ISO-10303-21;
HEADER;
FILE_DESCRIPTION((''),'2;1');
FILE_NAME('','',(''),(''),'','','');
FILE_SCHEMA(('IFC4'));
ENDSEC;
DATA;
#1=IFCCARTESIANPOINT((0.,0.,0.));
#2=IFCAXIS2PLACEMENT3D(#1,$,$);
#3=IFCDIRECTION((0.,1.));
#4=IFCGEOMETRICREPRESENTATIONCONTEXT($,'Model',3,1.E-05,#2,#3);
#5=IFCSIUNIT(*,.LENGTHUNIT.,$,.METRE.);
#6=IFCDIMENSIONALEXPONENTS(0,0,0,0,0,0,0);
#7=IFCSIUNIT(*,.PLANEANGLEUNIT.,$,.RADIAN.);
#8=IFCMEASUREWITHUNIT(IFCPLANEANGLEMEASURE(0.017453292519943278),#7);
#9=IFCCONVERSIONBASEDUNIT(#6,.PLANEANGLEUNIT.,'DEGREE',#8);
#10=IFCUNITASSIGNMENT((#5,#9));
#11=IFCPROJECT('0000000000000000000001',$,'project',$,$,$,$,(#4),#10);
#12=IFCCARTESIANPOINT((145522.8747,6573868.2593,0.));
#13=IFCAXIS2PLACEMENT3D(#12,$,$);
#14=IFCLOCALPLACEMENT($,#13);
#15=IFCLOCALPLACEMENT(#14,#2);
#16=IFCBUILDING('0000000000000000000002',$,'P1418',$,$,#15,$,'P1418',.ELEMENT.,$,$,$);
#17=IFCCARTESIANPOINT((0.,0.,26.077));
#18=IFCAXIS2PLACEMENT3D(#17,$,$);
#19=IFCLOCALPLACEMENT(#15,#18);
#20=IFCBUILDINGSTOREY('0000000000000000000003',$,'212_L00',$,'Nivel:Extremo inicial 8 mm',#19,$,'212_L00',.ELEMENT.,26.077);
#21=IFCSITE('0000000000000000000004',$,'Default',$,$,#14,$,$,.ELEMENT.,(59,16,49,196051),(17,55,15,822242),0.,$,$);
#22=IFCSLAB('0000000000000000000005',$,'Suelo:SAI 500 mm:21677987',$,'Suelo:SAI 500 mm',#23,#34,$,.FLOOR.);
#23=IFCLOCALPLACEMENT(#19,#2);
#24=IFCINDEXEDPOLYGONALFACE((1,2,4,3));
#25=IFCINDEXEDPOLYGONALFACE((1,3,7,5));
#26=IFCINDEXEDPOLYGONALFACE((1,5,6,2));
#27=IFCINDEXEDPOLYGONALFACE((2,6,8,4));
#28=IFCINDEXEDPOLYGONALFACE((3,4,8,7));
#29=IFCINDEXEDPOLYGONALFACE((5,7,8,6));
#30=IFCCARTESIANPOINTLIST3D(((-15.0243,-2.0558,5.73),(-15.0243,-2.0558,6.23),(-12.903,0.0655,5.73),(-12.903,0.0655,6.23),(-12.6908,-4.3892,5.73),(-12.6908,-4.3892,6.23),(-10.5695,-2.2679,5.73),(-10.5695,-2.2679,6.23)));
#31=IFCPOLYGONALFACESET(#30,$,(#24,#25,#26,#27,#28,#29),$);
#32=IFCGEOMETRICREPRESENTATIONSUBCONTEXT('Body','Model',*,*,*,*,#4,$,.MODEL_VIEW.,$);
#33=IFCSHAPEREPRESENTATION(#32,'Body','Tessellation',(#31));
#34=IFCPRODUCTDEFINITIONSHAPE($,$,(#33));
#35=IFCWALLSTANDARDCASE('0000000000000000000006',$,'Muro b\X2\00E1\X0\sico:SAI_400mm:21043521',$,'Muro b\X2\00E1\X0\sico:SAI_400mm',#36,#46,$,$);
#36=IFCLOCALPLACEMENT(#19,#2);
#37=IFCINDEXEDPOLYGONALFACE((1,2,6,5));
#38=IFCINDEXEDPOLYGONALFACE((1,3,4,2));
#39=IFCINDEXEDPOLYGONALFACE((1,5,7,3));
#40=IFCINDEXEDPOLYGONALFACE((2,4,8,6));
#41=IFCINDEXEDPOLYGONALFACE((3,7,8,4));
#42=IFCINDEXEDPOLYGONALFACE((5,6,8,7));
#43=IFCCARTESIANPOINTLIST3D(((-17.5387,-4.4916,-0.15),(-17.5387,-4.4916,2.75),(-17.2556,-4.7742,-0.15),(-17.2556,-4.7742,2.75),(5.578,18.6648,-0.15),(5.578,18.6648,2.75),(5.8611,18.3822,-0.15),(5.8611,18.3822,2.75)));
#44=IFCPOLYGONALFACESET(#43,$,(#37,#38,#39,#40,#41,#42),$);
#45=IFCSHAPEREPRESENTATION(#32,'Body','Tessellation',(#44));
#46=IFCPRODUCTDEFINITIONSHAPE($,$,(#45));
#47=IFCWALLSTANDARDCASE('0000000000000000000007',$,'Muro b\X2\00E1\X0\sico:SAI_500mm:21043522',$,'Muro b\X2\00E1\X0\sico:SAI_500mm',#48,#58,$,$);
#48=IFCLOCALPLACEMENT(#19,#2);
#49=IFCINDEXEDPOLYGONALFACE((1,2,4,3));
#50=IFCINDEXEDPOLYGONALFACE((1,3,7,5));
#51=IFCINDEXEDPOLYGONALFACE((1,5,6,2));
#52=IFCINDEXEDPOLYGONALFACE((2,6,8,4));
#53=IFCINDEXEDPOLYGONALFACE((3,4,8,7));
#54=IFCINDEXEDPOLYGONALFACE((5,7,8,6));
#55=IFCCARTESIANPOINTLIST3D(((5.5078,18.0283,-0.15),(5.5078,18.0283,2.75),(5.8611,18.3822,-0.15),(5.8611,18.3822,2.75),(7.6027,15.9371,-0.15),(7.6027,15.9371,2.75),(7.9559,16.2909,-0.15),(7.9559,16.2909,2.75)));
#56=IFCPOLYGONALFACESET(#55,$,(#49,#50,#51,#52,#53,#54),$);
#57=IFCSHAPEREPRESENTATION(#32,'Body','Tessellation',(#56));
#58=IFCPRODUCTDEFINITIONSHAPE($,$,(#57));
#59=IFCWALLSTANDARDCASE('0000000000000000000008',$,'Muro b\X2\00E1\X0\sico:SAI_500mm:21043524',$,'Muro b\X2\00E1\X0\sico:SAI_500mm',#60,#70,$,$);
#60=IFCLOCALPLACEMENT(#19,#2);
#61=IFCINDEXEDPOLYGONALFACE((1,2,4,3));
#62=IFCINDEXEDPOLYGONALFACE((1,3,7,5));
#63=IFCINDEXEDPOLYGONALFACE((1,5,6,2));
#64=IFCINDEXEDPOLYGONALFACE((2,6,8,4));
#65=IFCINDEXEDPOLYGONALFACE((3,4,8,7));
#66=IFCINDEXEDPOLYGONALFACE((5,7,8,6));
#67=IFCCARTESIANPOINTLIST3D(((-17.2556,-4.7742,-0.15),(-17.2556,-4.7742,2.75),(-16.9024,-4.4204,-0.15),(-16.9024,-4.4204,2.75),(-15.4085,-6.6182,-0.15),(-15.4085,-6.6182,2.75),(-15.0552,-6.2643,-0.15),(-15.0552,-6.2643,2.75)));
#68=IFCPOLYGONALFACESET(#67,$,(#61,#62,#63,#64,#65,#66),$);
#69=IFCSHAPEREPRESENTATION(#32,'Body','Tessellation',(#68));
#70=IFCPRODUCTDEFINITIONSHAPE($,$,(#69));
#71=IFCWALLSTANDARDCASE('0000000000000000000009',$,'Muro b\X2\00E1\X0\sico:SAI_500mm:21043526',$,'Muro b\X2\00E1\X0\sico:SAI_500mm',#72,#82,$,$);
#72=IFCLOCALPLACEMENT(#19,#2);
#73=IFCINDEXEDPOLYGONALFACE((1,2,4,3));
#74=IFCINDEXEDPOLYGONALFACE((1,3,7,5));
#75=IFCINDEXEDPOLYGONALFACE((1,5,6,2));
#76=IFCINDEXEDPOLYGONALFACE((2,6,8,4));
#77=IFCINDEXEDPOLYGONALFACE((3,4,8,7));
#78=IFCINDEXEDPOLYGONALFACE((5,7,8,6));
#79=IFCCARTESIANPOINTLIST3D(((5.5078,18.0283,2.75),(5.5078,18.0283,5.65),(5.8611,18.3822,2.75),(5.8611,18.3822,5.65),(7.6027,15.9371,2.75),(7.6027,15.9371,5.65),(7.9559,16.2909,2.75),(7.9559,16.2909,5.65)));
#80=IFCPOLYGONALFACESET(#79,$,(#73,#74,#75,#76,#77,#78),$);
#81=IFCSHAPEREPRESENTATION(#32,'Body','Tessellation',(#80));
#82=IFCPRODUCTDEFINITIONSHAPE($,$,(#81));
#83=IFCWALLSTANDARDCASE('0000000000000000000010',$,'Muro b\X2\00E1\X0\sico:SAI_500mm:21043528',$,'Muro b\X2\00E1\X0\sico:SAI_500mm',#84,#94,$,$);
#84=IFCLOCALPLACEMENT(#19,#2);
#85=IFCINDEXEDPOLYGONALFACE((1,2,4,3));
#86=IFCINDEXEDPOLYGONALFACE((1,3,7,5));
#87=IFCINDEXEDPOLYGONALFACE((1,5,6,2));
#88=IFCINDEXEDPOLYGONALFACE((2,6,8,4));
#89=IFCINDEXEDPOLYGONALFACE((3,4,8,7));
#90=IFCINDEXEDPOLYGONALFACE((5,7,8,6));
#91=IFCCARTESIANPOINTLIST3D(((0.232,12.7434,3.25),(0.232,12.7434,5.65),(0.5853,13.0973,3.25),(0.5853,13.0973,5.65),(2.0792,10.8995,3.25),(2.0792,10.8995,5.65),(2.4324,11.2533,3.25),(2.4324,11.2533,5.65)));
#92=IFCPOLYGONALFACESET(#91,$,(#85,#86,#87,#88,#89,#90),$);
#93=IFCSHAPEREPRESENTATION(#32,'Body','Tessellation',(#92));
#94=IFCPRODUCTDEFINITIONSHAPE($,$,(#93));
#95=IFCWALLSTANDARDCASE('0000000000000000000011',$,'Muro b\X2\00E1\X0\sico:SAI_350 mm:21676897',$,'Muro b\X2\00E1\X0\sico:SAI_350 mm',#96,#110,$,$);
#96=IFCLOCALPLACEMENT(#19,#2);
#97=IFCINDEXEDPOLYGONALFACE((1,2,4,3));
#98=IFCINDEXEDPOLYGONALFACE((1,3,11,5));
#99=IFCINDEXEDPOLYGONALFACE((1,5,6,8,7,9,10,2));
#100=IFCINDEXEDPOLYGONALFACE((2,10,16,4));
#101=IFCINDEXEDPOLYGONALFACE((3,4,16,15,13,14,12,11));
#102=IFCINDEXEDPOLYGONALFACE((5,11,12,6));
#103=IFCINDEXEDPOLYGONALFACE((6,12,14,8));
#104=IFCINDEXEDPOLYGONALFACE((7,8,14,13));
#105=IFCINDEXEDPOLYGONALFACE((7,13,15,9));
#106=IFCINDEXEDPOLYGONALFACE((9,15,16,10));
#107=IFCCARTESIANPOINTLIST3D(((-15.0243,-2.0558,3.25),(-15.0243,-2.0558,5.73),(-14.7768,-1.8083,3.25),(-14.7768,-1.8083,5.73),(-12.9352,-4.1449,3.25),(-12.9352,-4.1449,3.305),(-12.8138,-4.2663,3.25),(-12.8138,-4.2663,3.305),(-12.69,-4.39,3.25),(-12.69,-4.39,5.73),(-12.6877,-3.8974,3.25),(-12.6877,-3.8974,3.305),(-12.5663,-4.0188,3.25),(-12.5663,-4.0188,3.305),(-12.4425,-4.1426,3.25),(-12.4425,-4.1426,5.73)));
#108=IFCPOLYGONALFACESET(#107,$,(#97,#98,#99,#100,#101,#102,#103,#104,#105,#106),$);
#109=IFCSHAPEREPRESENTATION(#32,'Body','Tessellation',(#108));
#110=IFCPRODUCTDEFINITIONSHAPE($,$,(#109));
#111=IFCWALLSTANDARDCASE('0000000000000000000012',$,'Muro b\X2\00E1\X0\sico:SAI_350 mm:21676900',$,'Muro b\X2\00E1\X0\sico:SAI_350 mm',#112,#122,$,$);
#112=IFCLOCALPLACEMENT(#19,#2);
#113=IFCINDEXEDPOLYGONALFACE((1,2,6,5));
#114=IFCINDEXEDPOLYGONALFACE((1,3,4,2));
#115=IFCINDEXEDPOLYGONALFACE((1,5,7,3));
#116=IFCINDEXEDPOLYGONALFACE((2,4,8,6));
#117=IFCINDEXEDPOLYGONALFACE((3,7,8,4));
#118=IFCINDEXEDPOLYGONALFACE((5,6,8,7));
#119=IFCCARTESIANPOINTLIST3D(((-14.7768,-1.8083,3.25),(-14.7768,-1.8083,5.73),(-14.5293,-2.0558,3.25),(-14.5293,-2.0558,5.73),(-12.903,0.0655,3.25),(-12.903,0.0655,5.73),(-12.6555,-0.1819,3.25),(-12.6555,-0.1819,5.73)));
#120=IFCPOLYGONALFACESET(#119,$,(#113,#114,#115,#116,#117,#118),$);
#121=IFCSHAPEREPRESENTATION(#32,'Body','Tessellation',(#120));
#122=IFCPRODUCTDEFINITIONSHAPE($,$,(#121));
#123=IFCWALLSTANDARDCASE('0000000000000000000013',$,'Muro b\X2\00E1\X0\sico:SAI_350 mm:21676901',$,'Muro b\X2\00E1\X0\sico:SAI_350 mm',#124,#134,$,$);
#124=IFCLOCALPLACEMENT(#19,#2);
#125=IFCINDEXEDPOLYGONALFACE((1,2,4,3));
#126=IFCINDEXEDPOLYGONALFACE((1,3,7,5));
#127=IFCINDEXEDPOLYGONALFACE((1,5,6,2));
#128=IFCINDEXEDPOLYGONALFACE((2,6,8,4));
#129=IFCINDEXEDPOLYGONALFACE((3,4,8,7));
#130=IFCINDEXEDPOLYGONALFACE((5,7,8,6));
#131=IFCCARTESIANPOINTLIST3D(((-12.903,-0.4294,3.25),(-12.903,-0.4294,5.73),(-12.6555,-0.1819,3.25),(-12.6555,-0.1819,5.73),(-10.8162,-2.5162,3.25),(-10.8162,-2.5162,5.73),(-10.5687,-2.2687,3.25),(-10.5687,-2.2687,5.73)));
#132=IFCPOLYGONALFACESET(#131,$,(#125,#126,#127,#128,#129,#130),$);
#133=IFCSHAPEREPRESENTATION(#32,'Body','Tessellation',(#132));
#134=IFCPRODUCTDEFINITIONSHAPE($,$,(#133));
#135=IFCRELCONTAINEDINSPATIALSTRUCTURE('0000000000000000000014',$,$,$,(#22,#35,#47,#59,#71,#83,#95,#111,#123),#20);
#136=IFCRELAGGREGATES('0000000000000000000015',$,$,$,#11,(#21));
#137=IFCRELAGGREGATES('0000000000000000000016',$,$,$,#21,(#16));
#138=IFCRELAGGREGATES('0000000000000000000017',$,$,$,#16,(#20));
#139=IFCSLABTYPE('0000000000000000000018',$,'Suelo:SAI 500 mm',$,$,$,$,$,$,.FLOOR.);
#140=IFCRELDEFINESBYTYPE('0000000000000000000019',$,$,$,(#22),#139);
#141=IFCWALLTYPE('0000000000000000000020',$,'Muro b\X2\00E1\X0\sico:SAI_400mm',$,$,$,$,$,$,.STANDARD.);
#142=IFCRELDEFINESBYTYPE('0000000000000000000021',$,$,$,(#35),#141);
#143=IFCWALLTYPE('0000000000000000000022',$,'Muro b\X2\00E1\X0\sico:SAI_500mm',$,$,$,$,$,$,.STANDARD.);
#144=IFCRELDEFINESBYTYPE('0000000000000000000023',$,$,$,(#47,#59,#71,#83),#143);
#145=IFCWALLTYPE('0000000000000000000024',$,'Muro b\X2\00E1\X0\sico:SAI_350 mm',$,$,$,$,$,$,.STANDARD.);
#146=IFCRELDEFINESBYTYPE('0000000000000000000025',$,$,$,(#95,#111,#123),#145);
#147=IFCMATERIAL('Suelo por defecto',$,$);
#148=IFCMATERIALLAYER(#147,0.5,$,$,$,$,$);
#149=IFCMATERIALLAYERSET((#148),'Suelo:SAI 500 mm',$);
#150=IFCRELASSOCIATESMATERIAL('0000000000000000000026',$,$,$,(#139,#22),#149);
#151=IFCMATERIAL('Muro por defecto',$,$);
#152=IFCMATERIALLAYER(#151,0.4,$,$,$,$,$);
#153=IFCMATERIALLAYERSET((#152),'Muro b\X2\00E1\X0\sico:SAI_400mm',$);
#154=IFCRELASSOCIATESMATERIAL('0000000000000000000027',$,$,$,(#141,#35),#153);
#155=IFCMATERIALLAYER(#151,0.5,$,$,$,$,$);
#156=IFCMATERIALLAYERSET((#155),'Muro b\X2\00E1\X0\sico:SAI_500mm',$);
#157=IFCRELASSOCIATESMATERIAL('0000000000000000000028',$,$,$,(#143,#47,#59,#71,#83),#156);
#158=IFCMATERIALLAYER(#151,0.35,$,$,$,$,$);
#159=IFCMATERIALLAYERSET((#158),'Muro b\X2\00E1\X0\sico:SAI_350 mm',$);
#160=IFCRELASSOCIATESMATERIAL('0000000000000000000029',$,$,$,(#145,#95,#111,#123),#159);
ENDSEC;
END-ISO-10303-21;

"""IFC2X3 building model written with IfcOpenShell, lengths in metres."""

from ifc_helpers import new_model, entity, si_unit, converted_unit, direction, frame, frame_2d, origin, place, context, subcontext, project, spatial, rectangle, extrude, material, layer, layer_set, layer_usage, type_object, element, save


model = new_model("IFC2X3")

# Units and contexts
model_context = context("Model", 3, precision=1e-05, world=origin(), true_north=direction((0.0, 1.0)))
body_context = subcontext(model_context, "Body", "Model", "MODEL_VIEW")
ifc_project = project(units=[si_unit("LENGTHUNIT", "METRE"), converted_unit("PLANEANGLEUNIT", "DEGREE", entity("IfcPlaneAngleMeasure", 0.017453292519943278), si_unit("PLANEANGLEUNIT", "RADIAN"), dimensions=[0, 0, 0, 0, 0, 0, 0])], contexts=[model_context])

# Site, building, storey
site_placement = place(None, frame((145522.8747, 6573868.2593, 0.0)))
site = spatial("IfcSite", under=ifc_project, at=site_placement, Name="Default", CompositionType="ELEMENT", RefLatitude=(59, 16, 49, 196051), RefLongitude=(17, 55, 15, 822242), RefElevation=0.0)
building_placement = place(site_placement, origin())
building = spatial("IfcBuilding", under=site, at=building_placement, Name="P1418", LongName="P1418", CompositionType="ELEMENT")
storey_placement = place(building_placement, frame((0.0, 0.0, 26.077)))
storey = spatial("IfcBuildingStorey", under=building, at=storey_placement, Name="212_L00", ObjectType="Nivel:Extremo inicial 8 mm", LongName="212_L00", CompositionType="ELEMENT", Elevation=26.077)

# Shared definitions
ifc_material_1 = material(Name="Suelo por defecto")
ifc_layer_1 = layer(ifc_material_1, 0.5)
ifc_layer_set_1 = layer_set([ifc_layer_1], Name="Suelo:SAI 500 mm")
slab_type = type_object("IfcSlabType", Name="Suelo:SAI 500 mm", PredefinedType="FLOOR", material=ifc_layer_set_1)

# Slab
ifc_layer_usage_1 = layer_usage(ifc_layer_set_1, "AXIS3", "POSITIVE", 0.0)
slab_1_placement = place(storey_placement, origin())
element("IfcSlab", 1, at=slab_1_placement, inside=storey, type_object=slab_type, material=ifc_layer_usage_1, Name="Suelo:SAI 500 mm:21677987", ObjectType="Suelo:SAI 500 mm", PredefinedType="FLOOR", context=body_context, shape_type="SweptSolid", body=[
    extrude(rectangle(XDim=3.3, YDim=3.0, at=frame_2d((0.0, 0.0), x_axis=(1.0, 0.0))), frame((-12.7969, -2.1618, 6.23), z_axis=(0.0, 0.0, -1.0), x_axis=(0.707107, -0.707107, 0.0)), (0.0, 0.0, 1.0), 0.5),
])

# Shared definitions
ifc_material_2 = material(Name="Muro por defecto")
ifc_layer_2 = layer(ifc_material_2, 0.4)
ifc_layer_set_2 = layer_set([ifc_layer_2], Name="Muro básico:SAI_400mm")
wall_type_1 = type_object("IfcWallType", Name="Muro básico:SAI_400mm", PredefinedType="STANDARD", material=ifc_layer_set_2)

# Wall
ifc_layer_usage_2 = layer_usage(ifc_layer_set_2, "AXIS2", "POSITIVE", -0.2)
wall_1_placement = place(storey_placement, frame((-17.3971, -4.6329, -0.15), z_axis=(0.0, 0.0, 1.0), x_axis=(0.7065, 0.707713, 0.0)))
element("IfcWallStandardCase", 2, at=wall_1_placement, inside=storey, type_object=wall_type_1, material=ifc_layer_usage_2, Name="Muro básico:SAI_400mm:21043521", ObjectType="Muro básico:SAI_400mm", context=body_context, shape_type="SweptSolid", body=[
    extrude(rectangle(XDim=32.72, YDim=0.4, at=frame_2d((16.36, 0.0), x_axis=(-1.0, 0.0))), origin(), (0.0, 0.0, 1.0), 2.9),
])

# Walls
ifc_layer_3 = layer(ifc_material_2, 0.5)
ifc_layer_set_3 = layer_set([ifc_layer_3], Name="Muro básico:SAI_500mm")
ifc_layer_usage_3 = layer_usage(ifc_layer_set_3, "AXIS2", "POSITIVE", -0.25)
wall_type_2 = type_object("IfcWallType", Name="Muro básico:SAI_500mm", PredefinedType="STANDARD", material=ifc_layer_set_3)
wall_2_placement = place(storey_placement, frame((7.7793, 16.114, -0.15), z_axis=(0.0, 0.0, 1.0), x_axis=(-0.707713, 0.7065, 0.0)))
element("IfcWallStandardCase", 3, at=wall_2_placement, inside=storey, type_object=wall_type_2, material=ifc_layer_usage_3, Name="Muro básico:SAI_500mm:21043522", ObjectType="Muro básico:SAI_500mm", context=body_context, shape_type="SweptSolid", body=[
    extrude(rectangle(XDim=2.96, YDim=0.5, at=frame_2d((1.48, 0.0), x_axis=(-1.0, 0.0))), origin(), (0.0, 0.0, 1.0), 2.9),
])
ifc_layer_usage_4 = layer_usage(ifc_layer_set_3, "AXIS2", "POSITIVE", -0.25)
wall_3_placement = place(storey_placement, frame((-15.2318, -6.4413, -0.15), z_axis=(0.0, 0.0, 1.0), x_axis=(-0.707713, 0.7065, 0.0)))
element("IfcWallStandardCase", 4, at=wall_3_placement, inside=storey, type_object=wall_type_2, material=ifc_layer_usage_4, Name="Muro básico:SAI_500mm:21043524", ObjectType="Muro básico:SAI_500mm", context=body_context, shape_type="SweptSolid", body=[
    extrude(rectangle(XDim=2.61, YDim=0.5, at=frame_2d((1.305, 0.0), x_axis=(-1.0, 0.0))), origin(), (0.0, 0.0, 1.0), 2.9),
])
ifc_layer_usage_5 = layer_usage(ifc_layer_set_3, "AXIS2", "POSITIVE", -0.25)
wall_4_placement = place(storey_placement, frame((7.7793, 16.114, 2.75), z_axis=(0.0, 0.0, 1.0), x_axis=(-0.707713, 0.7065, 0.0)))
element("IfcWallStandardCase", 5, at=wall_4_placement, inside=storey, type_object=wall_type_2, material=ifc_layer_usage_5, Name="Muro básico:SAI_500mm:21043526", ObjectType="Muro básico:SAI_500mm", context=body_context, shape_type="SweptSolid", body=[
    extrude(rectangle(XDim=2.96, YDim=0.5, at=frame_2d((1.48, 0.0), x_axis=(-1.0, 0.0))), origin(), (0.0, 0.0, 1.0), 2.9),
])
ifc_layer_usage_6 = layer_usage(ifc_layer_set_3, "AXIS2", "POSITIVE", -0.25)
wall_5_placement = place(storey_placement, frame((2.2558, 11.0764, 3.25), z_axis=(0.0, 0.0, 1.0), x_axis=(-0.707713, 0.7065, 0.0)))
element("IfcWallStandardCase", 6, at=wall_5_placement, inside=storey, type_object=wall_type_2, material=ifc_layer_usage_6, Name="Muro básico:SAI_500mm:21043528", ObjectType="Muro básico:SAI_500mm", context=body_context, shape_type="SweptSolid", body=[
    extrude(rectangle(XDim=2.61, YDim=0.5, at=frame_2d((1.305, 0.0), x_axis=(-1.0, 0.0))), origin(), (0.0, 0.0, 1.0), 2.4),
])

# Shared definitions
ifc_layer_4 = layer(ifc_material_2, 0.35)
ifc_layer_set_4 = layer_set([ifc_layer_4], Name="Muro básico:SAI_350 mm")
wall_type_3 = type_object("IfcWallType", Name="Muro básico:SAI_350 mm", PredefinedType="STANDARD", material=ifc_layer_set_4)

# Wall, opening
ifc_layer_usage_7 = layer_usage(ifc_layer_set_4, "AXIS2", "POSITIVE", -0.175)
wall_6_placement = place(storey_placement, frame((-14.9005, -1.932, 3.25), z_axis=(0.0, 0.0, 1.0), x_axis=(0.707107, -0.707107, 0.0)))
wall_6 = element("IfcWallStandardCase", 7, at=wall_6_placement, inside=storey, type_object=wall_type_3, material=ifc_layer_usage_7, Name="Muro básico:SAI_350 mm:21676897", ObjectType="Muro básico:SAI_350 mm", context=body_context, shape_type="SweptSolid", body=[
    extrude(rectangle(XDim=3.3012, YDim=0.35, at=frame_2d((1.6506, 0.0), x_axis=(-1.0, 0.0))), origin(), (0.0, 0.0, 1.0), 2.48),
])
opening_1_placement = place(wall_6_placement, origin())
element("IfcOpeningElement", 8, at=opening_1_placement, cuts=wall_6, ObjectType="Opening", context=body_context, shape_type="SweptSolid", body=[
    extrude(rectangle(XDim=0.055, YDim=0.1717, at=frame_2d((0.0, 0.0), x_axis=(0.0, 1.0))), frame((3.0403, 0.175, 0.0275), z_axis=(0.0, -1.0, 0.0), x_axis=(1.0, 0.0, 0.0)), (0.0, 0.0, 1.0), 0.35),
])

# Walls
ifc_layer_usage_8 = layer_usage(ifc_layer_set_4, "AXIS2", "NEGATIVE", 0.175)
wall_7_placement = place(storey_placement, frame((-14.6531, -1.932, 3.25), z_axis=(0.0, 0.0, 1.0), x_axis=(0.707107, 0.707107, 0.0)))
element("IfcWallStandardCase", 9, at=wall_7_placement, inside=storey, type_object=wall_type_3, material=ifc_layer_usage_8, Name="Muro básico:SAI_350 mm:21676900", ObjectType="Muro básico:SAI_350 mm", context=body_context, shape_type="SweptSolid", body=[
    extrude(rectangle(XDim=2.65, YDim=0.35, at=frame_2d((1.325, 0.0), x_axis=(-1.0, 0.0))), origin(), (0.0, 0.0, 1.0), 2.48),
])
ifc_layer_usage_9 = layer_usage(ifc_layer_set_4, "AXIS2", "NEGATIVE", 0.175)
wall_8_placement = place(storey_placement, frame((-12.7792, -0.3057, 3.25), z_axis=(0.0, 0.0, 1.0), x_axis=(0.707107, -0.707107, 0.0)))
element("IfcWallStandardCase", 10, at=wall_8_placement, inside=storey, type_object=wall_type_3, material=ifc_layer_usage_9, Name="Muro básico:SAI_350 mm:21676901", ObjectType="Muro básico:SAI_350 mm", context=body_context, shape_type="SweptSolid", body=[
    extrude(rectangle(XDim=2.9512, YDim=0.35, at=frame_2d((1.4756, 0.0), x_axis=(-1.0, 0.0))), origin(), (0.0, 0.0, 1.0), 2.48),
])

save(model, "model.ifc")
